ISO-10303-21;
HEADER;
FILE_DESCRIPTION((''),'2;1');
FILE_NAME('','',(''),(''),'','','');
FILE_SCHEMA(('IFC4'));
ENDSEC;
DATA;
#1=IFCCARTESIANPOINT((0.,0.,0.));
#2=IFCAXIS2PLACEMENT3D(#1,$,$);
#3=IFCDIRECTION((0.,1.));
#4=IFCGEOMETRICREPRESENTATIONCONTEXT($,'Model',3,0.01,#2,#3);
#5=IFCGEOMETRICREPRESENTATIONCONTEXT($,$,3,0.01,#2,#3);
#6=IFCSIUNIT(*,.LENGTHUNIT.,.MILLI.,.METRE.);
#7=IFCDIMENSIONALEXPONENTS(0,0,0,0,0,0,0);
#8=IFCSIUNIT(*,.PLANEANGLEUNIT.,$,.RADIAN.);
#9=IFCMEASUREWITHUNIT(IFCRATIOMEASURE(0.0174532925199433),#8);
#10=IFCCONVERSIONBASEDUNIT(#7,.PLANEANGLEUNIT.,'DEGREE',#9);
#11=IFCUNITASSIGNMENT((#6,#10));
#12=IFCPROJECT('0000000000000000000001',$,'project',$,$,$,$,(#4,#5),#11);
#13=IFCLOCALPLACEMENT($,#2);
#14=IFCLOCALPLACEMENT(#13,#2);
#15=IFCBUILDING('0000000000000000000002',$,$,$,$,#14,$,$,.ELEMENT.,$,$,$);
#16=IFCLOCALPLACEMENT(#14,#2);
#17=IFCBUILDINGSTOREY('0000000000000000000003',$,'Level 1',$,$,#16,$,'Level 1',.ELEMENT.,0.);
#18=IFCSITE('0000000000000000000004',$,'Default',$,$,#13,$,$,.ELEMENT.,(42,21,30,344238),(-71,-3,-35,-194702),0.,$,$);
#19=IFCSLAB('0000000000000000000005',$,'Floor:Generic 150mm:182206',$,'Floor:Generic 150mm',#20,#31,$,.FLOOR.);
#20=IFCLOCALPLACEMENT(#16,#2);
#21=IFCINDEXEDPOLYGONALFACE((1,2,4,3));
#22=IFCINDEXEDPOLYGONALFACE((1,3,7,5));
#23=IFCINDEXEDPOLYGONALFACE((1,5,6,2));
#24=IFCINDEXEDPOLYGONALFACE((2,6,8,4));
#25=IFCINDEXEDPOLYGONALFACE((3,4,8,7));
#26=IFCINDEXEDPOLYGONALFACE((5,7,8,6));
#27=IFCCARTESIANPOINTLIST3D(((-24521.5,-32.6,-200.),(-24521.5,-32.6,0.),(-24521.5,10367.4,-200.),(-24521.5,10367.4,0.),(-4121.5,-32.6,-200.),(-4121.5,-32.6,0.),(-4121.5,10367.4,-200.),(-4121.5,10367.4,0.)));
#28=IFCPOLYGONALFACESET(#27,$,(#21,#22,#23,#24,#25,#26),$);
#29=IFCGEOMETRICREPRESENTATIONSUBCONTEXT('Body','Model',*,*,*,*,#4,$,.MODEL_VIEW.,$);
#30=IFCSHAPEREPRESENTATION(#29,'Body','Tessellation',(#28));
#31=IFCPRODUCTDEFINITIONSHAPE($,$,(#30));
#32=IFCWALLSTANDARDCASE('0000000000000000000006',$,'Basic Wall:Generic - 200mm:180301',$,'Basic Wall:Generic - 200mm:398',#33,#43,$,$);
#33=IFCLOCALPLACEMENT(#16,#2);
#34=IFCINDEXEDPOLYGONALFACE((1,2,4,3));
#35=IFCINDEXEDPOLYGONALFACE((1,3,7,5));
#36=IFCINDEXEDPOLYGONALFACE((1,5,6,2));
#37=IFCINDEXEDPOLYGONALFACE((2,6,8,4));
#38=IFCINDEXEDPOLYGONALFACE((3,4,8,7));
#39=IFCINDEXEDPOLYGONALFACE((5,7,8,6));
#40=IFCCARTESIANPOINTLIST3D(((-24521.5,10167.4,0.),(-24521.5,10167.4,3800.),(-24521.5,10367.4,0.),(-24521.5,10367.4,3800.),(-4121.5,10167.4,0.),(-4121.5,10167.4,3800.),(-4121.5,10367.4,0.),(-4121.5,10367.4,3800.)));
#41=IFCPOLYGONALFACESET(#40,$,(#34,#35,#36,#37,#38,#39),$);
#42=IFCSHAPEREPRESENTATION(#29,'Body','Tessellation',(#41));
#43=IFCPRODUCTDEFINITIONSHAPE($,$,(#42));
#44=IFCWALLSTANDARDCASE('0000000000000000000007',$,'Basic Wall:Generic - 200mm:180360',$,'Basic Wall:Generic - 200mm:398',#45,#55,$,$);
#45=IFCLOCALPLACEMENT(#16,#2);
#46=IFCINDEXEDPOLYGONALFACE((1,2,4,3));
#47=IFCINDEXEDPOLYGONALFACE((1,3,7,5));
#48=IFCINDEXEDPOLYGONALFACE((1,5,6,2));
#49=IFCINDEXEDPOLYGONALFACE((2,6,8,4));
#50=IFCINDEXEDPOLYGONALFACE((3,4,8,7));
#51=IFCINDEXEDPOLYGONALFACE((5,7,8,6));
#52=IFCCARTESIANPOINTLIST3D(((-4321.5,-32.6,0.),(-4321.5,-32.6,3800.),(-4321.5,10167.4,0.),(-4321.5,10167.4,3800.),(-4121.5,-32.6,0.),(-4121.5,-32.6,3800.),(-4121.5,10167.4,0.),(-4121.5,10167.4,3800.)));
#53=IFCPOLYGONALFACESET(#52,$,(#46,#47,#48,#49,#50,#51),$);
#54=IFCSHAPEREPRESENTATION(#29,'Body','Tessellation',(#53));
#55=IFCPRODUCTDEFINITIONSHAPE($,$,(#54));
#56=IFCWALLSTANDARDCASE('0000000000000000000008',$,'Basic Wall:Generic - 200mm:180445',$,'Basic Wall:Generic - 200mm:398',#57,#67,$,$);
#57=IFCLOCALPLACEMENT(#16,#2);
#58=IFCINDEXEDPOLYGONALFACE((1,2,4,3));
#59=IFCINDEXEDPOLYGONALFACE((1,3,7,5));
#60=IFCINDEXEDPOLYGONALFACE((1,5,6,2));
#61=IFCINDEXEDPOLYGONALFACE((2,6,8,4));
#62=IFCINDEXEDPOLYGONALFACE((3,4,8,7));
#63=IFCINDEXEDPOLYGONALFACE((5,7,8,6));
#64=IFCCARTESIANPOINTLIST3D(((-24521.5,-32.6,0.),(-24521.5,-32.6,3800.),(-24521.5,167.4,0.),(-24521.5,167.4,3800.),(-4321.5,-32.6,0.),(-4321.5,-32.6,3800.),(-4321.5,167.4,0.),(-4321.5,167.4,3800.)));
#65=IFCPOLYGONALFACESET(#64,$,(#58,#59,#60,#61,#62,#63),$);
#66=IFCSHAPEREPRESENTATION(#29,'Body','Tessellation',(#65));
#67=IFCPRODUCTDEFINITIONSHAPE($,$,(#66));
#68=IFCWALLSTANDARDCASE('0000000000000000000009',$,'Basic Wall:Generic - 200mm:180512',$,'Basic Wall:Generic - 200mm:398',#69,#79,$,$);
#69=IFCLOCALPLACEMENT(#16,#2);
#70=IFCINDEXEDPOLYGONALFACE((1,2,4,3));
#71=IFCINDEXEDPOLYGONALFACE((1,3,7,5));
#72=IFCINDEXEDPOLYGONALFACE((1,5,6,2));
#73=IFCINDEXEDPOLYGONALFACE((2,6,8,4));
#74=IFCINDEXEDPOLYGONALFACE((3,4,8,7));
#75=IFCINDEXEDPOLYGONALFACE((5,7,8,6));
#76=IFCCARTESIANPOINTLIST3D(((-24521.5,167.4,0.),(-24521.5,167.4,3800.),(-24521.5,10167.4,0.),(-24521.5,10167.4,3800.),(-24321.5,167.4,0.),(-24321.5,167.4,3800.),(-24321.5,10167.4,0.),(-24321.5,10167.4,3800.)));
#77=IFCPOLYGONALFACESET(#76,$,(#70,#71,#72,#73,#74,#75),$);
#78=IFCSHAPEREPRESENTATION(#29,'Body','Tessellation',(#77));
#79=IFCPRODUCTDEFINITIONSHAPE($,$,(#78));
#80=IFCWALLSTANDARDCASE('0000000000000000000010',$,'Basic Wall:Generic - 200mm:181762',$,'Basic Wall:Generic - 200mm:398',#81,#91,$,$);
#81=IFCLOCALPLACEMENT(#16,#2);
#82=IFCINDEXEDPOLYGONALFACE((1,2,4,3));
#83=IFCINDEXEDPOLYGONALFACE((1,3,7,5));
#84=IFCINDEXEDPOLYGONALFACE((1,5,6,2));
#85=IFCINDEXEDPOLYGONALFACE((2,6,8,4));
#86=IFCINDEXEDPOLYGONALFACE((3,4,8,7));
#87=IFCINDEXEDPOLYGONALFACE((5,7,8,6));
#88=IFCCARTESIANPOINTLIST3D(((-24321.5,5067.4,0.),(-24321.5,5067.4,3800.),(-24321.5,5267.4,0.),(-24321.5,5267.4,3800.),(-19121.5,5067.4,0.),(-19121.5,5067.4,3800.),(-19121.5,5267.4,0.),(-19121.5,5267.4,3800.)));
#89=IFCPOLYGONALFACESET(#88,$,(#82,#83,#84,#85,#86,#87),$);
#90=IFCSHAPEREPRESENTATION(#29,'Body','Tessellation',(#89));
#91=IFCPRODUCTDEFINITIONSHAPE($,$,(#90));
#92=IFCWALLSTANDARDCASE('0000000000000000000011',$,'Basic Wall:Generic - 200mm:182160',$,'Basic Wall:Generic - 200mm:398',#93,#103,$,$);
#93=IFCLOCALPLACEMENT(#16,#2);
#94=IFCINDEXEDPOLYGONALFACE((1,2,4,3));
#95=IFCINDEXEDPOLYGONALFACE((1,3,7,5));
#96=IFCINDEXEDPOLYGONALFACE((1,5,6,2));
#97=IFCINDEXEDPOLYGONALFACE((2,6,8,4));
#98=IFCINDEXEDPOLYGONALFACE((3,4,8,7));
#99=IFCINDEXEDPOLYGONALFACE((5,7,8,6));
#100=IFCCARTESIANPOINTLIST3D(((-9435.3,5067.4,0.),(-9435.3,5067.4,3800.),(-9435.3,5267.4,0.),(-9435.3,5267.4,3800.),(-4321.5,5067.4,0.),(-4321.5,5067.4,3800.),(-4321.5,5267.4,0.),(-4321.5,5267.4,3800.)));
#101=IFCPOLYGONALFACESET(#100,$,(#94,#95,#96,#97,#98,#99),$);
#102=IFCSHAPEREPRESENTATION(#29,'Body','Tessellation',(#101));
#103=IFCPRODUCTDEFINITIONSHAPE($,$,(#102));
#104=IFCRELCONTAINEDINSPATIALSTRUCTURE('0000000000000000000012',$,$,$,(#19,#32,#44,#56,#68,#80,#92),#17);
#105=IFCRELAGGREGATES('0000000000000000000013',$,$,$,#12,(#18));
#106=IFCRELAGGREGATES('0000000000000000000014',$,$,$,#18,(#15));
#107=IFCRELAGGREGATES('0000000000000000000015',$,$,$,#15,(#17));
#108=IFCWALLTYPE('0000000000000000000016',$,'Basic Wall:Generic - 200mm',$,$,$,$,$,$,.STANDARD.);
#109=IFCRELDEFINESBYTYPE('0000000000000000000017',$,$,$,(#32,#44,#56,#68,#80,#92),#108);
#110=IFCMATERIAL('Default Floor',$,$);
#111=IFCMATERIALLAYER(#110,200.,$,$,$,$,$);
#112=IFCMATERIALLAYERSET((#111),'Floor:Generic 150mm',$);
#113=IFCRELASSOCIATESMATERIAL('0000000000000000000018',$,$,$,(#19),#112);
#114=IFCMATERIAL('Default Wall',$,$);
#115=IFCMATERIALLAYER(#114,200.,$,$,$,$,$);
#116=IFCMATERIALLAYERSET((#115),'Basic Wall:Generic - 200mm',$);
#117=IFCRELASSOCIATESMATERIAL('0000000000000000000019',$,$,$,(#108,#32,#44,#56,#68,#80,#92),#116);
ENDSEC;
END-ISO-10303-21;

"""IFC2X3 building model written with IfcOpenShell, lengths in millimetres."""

from ifc_helpers import new_model, entity, si_unit, converted_unit, direction, frame, frame_2d, origin, place, context, subcontext, project, spatial, rectangle, extrude, material, layer, layer_set, layer_usage, type_object, element, save


model = new_model("IFC2X3")

# Units and contexts
model_context = context("Model", 3, precision=0.01, world=origin(), true_north=direction((0.0, 1.0)))
context_of_model = context(None, 3, precision=0.01, world=origin(), true_north=direction((0.0, 1.0)))
body_context = subcontext(model_context, "Body", "Model", "MODEL_VIEW")
ifc_project = project(units=[si_unit("LENGTHUNIT", "METRE", prefix="MILLI"), converted_unit("PLANEANGLEUNIT", "DEGREE", entity("IfcRatioMeasure", 0.0174532925199433), si_unit("PLANEANGLEUNIT", "RADIAN"), dimensions=[0, 0, 0, 0, 0, 0, 0])], contexts=[model_context, context_of_model])

# Site, building, storey
site_placement = place(None, origin())
site = spatial("IfcSite", under=ifc_project, at=site_placement, Name="Default", CompositionType="ELEMENT", RefLatitude=(42, 21, 30, 344238), RefLongitude=(-71, -3, -35, -194702), RefElevation=0.0)
building_placement = place(site_placement, origin())
building = spatial("IfcBuilding", under=site, at=building_placement, CompositionType="ELEMENT")
storey_placement = place(building_placement, origin())
storey = spatial("IfcBuildingStorey", under=building, at=storey_placement, Name="Level 1", LongName="Level 1", CompositionType="ELEMENT", Elevation=0.0)

# Slab
ifc_material_1 = material(Name="Default Floor")
ifc_layer_1 = layer(ifc_material_1, 200.0)
ifc_layer_set_1 = layer_set([ifc_layer_1], Name="Floor:Generic 150mm")
ifc_layer_usage_1 = layer_usage(ifc_layer_set_1, "AXIS3", "POSITIVE", 0.0)
slab_placement = place(storey_placement, origin())
element("IfcSlab", 1, at=slab_placement, inside=storey, material=ifc_layer_usage_1, Name="Floor:Generic 150mm:182206", ObjectType="Floor:Generic 150mm", PredefinedType="FLOOR", context=body_context, shape_type="SweptSolid", body=[
    extrude(rectangle(XDim=10400.0, YDim=20400.0, at=frame_2d((0.0, 0.0), x_axis=(1.0, 0.0))), frame((-14321.5, 5167.4, 0.0), z_axis=(0.0, 0.0, -1.0), x_axis=(0.0, 1.0, 0.0)), (0.0, 0.0, 1.0), 200.0),
])

# Walls
ifc_material_2 = material(Name="Default Wall")
ifc_layer_2 = layer(ifc_material_2, 200.0)
ifc_layer_set_2 = layer_set([ifc_layer_2], Name="Basic Wall:Generic - 200mm")
ifc_layer_usage_2 = layer_usage(ifc_layer_set_2, "AXIS2", "NEGATIVE", 100.0)
wall_type = type_object("IfcWallType", Name="Basic Wall:Generic - 200mm", PredefinedType="STANDARD", material=ifc_layer_set_2)
wall_1_placement = place(storey_placement, frame((-24521.5, 10267.4, 0.0)))
element("IfcWallStandardCase", 2, at=wall_1_placement, inside=storey, type_object=wall_type, material=ifc_layer_usage_2, Name="Basic Wall:Generic - 200mm:180301", ObjectType="Basic Wall:Generic - 200mm:398", context=body_context, shape_type="SweptSolid", body=[
    extrude(rectangle(XDim=20400.0, YDim=200.0, at=frame_2d((10200.0, 0.0), x_axis=(-1.0, 0.0))), origin(), (0.0, 0.0, 1.0), 3800.0),
])
ifc_layer_usage_3 = layer_usage(ifc_layer_set_2, "AXIS2", "NEGATIVE", 100.0)
wall_2_placement = place(storey_placement, frame((-4221.5, 10167.4, 0.0), z_axis=(0.0, 0.0, 1.0), x_axis=(0.0, -1.0, 0.0)))
element("IfcWallStandardCase", 3, at=wall_2_placement, inside=storey, type_object=wall_type, material=ifc_layer_usage_3, Name="Basic Wall:Generic - 200mm:180360", ObjectType="Basic Wall:Generic - 200mm:398", context=body_context, shape_type="SweptSolid", body=[
    extrude(rectangle(XDim=10200.0, YDim=200.0, at=frame_2d((5100.0, 0.0), x_axis=(-1.0, 0.0))), origin(), (0.0, 0.0, 1.0), 3800.0),
])
ifc_layer_usage_4 = layer_usage(ifc_layer_set_2, "AXIS2", "NEGATIVE", 100.0)
wall_3_placement = place(storey_placement, frame((-4321.5, 67.4, 0.0), z_axis=(0.0, 0.0, 1.0), x_axis=(-1.0, 0.0, 0.0)))
element("IfcWallStandardCase", 4, at=wall_3_placement, inside=storey, type_object=wall_type, material=ifc_layer_usage_4, Name="Basic Wall:Generic - 200mm:180445", ObjectType="Basic Wall:Generic - 200mm:398", context=body_context, shape_type="SweptSolid", body=[
    extrude(rectangle(XDim=20200.0, YDim=200.0, at=frame_2d((10100.0, 0.0), x_axis=(-1.0, 0.0))), origin(), (0.0, 0.0, 1.0), 3800.0),
])
ifc_layer_usage_5 = layer_usage(ifc_layer_set_2, "AXIS2", "NEGATIVE", 100.0)
wall_4_placement = place(storey_placement, frame((-24421.5, 167.4, 0.0), z_axis=(0.0, 0.0, 1.0), x_axis=(0.0, 1.0, 0.0)))
element("IfcWallStandardCase", 5, at=wall_4_placement, inside=storey, type_object=wall_type, material=ifc_layer_usage_5, Name="Basic Wall:Generic - 200mm:180512", ObjectType="Basic Wall:Generic - 200mm:398", context=body_context, shape_type="SweptSolid", body=[
    extrude(rectangle(XDim=10000.0, YDim=200.0, at=frame_2d((5000.0, 0.0), x_axis=(-1.0, 0.0))), origin(), (0.0, 0.0, 1.0), 3800.0),
])
ifc_layer_usage_6 = layer_usage(ifc_layer_set_2, "AXIS2", "NEGATIVE", 100.0)
wall_5_placement = place(storey_placement, frame((-24321.5, 5167.4, 0.0)))
element("IfcWallStandardCase", 6, at=wall_5_placement, inside=storey, type_object=wall_type, material=ifc_layer_usage_6, Name="Basic Wall:Generic - 200mm:181762", ObjectType="Basic Wall:Generic - 200mm:398", context=body_context, shape_type="SweptSolid", body=[
    extrude(rectangle(XDim=5200.0, YDim=200.0, at=frame_2d((2600.0, 0.0), x_axis=(-1.0, 0.0))), origin(), (0.0, 0.0, 1.0), 3800.0),
])
ifc_layer_usage_7 = layer_usage(ifc_layer_set_2, "AXIS2", "NEGATIVE", 100.0)
wall_6_placement = place(storey_placement, frame((-4321.5, 5167.4, 0.0), z_axis=(0.0, 0.0, 1.0), x_axis=(-1.0, 0.0, 0.0)))
element("IfcWallStandardCase", 7, at=wall_6_placement, inside=storey, type_object=wall_type, material=ifc_layer_usage_7, Name="Basic Wall:Generic - 200mm:182160", ObjectType="Basic Wall:Generic - 200mm:398", context=body_context, shape_type="SweptSolid", body=[
    extrude(rectangle(XDim=5113.8, YDim=200.0, at=frame_2d((2556.9, 0.0), x_axis=(-1.0, 0.0))), origin(), (0.0, 0.0, 1.0), 3800.0),
])

save(model, "model.ifc")
